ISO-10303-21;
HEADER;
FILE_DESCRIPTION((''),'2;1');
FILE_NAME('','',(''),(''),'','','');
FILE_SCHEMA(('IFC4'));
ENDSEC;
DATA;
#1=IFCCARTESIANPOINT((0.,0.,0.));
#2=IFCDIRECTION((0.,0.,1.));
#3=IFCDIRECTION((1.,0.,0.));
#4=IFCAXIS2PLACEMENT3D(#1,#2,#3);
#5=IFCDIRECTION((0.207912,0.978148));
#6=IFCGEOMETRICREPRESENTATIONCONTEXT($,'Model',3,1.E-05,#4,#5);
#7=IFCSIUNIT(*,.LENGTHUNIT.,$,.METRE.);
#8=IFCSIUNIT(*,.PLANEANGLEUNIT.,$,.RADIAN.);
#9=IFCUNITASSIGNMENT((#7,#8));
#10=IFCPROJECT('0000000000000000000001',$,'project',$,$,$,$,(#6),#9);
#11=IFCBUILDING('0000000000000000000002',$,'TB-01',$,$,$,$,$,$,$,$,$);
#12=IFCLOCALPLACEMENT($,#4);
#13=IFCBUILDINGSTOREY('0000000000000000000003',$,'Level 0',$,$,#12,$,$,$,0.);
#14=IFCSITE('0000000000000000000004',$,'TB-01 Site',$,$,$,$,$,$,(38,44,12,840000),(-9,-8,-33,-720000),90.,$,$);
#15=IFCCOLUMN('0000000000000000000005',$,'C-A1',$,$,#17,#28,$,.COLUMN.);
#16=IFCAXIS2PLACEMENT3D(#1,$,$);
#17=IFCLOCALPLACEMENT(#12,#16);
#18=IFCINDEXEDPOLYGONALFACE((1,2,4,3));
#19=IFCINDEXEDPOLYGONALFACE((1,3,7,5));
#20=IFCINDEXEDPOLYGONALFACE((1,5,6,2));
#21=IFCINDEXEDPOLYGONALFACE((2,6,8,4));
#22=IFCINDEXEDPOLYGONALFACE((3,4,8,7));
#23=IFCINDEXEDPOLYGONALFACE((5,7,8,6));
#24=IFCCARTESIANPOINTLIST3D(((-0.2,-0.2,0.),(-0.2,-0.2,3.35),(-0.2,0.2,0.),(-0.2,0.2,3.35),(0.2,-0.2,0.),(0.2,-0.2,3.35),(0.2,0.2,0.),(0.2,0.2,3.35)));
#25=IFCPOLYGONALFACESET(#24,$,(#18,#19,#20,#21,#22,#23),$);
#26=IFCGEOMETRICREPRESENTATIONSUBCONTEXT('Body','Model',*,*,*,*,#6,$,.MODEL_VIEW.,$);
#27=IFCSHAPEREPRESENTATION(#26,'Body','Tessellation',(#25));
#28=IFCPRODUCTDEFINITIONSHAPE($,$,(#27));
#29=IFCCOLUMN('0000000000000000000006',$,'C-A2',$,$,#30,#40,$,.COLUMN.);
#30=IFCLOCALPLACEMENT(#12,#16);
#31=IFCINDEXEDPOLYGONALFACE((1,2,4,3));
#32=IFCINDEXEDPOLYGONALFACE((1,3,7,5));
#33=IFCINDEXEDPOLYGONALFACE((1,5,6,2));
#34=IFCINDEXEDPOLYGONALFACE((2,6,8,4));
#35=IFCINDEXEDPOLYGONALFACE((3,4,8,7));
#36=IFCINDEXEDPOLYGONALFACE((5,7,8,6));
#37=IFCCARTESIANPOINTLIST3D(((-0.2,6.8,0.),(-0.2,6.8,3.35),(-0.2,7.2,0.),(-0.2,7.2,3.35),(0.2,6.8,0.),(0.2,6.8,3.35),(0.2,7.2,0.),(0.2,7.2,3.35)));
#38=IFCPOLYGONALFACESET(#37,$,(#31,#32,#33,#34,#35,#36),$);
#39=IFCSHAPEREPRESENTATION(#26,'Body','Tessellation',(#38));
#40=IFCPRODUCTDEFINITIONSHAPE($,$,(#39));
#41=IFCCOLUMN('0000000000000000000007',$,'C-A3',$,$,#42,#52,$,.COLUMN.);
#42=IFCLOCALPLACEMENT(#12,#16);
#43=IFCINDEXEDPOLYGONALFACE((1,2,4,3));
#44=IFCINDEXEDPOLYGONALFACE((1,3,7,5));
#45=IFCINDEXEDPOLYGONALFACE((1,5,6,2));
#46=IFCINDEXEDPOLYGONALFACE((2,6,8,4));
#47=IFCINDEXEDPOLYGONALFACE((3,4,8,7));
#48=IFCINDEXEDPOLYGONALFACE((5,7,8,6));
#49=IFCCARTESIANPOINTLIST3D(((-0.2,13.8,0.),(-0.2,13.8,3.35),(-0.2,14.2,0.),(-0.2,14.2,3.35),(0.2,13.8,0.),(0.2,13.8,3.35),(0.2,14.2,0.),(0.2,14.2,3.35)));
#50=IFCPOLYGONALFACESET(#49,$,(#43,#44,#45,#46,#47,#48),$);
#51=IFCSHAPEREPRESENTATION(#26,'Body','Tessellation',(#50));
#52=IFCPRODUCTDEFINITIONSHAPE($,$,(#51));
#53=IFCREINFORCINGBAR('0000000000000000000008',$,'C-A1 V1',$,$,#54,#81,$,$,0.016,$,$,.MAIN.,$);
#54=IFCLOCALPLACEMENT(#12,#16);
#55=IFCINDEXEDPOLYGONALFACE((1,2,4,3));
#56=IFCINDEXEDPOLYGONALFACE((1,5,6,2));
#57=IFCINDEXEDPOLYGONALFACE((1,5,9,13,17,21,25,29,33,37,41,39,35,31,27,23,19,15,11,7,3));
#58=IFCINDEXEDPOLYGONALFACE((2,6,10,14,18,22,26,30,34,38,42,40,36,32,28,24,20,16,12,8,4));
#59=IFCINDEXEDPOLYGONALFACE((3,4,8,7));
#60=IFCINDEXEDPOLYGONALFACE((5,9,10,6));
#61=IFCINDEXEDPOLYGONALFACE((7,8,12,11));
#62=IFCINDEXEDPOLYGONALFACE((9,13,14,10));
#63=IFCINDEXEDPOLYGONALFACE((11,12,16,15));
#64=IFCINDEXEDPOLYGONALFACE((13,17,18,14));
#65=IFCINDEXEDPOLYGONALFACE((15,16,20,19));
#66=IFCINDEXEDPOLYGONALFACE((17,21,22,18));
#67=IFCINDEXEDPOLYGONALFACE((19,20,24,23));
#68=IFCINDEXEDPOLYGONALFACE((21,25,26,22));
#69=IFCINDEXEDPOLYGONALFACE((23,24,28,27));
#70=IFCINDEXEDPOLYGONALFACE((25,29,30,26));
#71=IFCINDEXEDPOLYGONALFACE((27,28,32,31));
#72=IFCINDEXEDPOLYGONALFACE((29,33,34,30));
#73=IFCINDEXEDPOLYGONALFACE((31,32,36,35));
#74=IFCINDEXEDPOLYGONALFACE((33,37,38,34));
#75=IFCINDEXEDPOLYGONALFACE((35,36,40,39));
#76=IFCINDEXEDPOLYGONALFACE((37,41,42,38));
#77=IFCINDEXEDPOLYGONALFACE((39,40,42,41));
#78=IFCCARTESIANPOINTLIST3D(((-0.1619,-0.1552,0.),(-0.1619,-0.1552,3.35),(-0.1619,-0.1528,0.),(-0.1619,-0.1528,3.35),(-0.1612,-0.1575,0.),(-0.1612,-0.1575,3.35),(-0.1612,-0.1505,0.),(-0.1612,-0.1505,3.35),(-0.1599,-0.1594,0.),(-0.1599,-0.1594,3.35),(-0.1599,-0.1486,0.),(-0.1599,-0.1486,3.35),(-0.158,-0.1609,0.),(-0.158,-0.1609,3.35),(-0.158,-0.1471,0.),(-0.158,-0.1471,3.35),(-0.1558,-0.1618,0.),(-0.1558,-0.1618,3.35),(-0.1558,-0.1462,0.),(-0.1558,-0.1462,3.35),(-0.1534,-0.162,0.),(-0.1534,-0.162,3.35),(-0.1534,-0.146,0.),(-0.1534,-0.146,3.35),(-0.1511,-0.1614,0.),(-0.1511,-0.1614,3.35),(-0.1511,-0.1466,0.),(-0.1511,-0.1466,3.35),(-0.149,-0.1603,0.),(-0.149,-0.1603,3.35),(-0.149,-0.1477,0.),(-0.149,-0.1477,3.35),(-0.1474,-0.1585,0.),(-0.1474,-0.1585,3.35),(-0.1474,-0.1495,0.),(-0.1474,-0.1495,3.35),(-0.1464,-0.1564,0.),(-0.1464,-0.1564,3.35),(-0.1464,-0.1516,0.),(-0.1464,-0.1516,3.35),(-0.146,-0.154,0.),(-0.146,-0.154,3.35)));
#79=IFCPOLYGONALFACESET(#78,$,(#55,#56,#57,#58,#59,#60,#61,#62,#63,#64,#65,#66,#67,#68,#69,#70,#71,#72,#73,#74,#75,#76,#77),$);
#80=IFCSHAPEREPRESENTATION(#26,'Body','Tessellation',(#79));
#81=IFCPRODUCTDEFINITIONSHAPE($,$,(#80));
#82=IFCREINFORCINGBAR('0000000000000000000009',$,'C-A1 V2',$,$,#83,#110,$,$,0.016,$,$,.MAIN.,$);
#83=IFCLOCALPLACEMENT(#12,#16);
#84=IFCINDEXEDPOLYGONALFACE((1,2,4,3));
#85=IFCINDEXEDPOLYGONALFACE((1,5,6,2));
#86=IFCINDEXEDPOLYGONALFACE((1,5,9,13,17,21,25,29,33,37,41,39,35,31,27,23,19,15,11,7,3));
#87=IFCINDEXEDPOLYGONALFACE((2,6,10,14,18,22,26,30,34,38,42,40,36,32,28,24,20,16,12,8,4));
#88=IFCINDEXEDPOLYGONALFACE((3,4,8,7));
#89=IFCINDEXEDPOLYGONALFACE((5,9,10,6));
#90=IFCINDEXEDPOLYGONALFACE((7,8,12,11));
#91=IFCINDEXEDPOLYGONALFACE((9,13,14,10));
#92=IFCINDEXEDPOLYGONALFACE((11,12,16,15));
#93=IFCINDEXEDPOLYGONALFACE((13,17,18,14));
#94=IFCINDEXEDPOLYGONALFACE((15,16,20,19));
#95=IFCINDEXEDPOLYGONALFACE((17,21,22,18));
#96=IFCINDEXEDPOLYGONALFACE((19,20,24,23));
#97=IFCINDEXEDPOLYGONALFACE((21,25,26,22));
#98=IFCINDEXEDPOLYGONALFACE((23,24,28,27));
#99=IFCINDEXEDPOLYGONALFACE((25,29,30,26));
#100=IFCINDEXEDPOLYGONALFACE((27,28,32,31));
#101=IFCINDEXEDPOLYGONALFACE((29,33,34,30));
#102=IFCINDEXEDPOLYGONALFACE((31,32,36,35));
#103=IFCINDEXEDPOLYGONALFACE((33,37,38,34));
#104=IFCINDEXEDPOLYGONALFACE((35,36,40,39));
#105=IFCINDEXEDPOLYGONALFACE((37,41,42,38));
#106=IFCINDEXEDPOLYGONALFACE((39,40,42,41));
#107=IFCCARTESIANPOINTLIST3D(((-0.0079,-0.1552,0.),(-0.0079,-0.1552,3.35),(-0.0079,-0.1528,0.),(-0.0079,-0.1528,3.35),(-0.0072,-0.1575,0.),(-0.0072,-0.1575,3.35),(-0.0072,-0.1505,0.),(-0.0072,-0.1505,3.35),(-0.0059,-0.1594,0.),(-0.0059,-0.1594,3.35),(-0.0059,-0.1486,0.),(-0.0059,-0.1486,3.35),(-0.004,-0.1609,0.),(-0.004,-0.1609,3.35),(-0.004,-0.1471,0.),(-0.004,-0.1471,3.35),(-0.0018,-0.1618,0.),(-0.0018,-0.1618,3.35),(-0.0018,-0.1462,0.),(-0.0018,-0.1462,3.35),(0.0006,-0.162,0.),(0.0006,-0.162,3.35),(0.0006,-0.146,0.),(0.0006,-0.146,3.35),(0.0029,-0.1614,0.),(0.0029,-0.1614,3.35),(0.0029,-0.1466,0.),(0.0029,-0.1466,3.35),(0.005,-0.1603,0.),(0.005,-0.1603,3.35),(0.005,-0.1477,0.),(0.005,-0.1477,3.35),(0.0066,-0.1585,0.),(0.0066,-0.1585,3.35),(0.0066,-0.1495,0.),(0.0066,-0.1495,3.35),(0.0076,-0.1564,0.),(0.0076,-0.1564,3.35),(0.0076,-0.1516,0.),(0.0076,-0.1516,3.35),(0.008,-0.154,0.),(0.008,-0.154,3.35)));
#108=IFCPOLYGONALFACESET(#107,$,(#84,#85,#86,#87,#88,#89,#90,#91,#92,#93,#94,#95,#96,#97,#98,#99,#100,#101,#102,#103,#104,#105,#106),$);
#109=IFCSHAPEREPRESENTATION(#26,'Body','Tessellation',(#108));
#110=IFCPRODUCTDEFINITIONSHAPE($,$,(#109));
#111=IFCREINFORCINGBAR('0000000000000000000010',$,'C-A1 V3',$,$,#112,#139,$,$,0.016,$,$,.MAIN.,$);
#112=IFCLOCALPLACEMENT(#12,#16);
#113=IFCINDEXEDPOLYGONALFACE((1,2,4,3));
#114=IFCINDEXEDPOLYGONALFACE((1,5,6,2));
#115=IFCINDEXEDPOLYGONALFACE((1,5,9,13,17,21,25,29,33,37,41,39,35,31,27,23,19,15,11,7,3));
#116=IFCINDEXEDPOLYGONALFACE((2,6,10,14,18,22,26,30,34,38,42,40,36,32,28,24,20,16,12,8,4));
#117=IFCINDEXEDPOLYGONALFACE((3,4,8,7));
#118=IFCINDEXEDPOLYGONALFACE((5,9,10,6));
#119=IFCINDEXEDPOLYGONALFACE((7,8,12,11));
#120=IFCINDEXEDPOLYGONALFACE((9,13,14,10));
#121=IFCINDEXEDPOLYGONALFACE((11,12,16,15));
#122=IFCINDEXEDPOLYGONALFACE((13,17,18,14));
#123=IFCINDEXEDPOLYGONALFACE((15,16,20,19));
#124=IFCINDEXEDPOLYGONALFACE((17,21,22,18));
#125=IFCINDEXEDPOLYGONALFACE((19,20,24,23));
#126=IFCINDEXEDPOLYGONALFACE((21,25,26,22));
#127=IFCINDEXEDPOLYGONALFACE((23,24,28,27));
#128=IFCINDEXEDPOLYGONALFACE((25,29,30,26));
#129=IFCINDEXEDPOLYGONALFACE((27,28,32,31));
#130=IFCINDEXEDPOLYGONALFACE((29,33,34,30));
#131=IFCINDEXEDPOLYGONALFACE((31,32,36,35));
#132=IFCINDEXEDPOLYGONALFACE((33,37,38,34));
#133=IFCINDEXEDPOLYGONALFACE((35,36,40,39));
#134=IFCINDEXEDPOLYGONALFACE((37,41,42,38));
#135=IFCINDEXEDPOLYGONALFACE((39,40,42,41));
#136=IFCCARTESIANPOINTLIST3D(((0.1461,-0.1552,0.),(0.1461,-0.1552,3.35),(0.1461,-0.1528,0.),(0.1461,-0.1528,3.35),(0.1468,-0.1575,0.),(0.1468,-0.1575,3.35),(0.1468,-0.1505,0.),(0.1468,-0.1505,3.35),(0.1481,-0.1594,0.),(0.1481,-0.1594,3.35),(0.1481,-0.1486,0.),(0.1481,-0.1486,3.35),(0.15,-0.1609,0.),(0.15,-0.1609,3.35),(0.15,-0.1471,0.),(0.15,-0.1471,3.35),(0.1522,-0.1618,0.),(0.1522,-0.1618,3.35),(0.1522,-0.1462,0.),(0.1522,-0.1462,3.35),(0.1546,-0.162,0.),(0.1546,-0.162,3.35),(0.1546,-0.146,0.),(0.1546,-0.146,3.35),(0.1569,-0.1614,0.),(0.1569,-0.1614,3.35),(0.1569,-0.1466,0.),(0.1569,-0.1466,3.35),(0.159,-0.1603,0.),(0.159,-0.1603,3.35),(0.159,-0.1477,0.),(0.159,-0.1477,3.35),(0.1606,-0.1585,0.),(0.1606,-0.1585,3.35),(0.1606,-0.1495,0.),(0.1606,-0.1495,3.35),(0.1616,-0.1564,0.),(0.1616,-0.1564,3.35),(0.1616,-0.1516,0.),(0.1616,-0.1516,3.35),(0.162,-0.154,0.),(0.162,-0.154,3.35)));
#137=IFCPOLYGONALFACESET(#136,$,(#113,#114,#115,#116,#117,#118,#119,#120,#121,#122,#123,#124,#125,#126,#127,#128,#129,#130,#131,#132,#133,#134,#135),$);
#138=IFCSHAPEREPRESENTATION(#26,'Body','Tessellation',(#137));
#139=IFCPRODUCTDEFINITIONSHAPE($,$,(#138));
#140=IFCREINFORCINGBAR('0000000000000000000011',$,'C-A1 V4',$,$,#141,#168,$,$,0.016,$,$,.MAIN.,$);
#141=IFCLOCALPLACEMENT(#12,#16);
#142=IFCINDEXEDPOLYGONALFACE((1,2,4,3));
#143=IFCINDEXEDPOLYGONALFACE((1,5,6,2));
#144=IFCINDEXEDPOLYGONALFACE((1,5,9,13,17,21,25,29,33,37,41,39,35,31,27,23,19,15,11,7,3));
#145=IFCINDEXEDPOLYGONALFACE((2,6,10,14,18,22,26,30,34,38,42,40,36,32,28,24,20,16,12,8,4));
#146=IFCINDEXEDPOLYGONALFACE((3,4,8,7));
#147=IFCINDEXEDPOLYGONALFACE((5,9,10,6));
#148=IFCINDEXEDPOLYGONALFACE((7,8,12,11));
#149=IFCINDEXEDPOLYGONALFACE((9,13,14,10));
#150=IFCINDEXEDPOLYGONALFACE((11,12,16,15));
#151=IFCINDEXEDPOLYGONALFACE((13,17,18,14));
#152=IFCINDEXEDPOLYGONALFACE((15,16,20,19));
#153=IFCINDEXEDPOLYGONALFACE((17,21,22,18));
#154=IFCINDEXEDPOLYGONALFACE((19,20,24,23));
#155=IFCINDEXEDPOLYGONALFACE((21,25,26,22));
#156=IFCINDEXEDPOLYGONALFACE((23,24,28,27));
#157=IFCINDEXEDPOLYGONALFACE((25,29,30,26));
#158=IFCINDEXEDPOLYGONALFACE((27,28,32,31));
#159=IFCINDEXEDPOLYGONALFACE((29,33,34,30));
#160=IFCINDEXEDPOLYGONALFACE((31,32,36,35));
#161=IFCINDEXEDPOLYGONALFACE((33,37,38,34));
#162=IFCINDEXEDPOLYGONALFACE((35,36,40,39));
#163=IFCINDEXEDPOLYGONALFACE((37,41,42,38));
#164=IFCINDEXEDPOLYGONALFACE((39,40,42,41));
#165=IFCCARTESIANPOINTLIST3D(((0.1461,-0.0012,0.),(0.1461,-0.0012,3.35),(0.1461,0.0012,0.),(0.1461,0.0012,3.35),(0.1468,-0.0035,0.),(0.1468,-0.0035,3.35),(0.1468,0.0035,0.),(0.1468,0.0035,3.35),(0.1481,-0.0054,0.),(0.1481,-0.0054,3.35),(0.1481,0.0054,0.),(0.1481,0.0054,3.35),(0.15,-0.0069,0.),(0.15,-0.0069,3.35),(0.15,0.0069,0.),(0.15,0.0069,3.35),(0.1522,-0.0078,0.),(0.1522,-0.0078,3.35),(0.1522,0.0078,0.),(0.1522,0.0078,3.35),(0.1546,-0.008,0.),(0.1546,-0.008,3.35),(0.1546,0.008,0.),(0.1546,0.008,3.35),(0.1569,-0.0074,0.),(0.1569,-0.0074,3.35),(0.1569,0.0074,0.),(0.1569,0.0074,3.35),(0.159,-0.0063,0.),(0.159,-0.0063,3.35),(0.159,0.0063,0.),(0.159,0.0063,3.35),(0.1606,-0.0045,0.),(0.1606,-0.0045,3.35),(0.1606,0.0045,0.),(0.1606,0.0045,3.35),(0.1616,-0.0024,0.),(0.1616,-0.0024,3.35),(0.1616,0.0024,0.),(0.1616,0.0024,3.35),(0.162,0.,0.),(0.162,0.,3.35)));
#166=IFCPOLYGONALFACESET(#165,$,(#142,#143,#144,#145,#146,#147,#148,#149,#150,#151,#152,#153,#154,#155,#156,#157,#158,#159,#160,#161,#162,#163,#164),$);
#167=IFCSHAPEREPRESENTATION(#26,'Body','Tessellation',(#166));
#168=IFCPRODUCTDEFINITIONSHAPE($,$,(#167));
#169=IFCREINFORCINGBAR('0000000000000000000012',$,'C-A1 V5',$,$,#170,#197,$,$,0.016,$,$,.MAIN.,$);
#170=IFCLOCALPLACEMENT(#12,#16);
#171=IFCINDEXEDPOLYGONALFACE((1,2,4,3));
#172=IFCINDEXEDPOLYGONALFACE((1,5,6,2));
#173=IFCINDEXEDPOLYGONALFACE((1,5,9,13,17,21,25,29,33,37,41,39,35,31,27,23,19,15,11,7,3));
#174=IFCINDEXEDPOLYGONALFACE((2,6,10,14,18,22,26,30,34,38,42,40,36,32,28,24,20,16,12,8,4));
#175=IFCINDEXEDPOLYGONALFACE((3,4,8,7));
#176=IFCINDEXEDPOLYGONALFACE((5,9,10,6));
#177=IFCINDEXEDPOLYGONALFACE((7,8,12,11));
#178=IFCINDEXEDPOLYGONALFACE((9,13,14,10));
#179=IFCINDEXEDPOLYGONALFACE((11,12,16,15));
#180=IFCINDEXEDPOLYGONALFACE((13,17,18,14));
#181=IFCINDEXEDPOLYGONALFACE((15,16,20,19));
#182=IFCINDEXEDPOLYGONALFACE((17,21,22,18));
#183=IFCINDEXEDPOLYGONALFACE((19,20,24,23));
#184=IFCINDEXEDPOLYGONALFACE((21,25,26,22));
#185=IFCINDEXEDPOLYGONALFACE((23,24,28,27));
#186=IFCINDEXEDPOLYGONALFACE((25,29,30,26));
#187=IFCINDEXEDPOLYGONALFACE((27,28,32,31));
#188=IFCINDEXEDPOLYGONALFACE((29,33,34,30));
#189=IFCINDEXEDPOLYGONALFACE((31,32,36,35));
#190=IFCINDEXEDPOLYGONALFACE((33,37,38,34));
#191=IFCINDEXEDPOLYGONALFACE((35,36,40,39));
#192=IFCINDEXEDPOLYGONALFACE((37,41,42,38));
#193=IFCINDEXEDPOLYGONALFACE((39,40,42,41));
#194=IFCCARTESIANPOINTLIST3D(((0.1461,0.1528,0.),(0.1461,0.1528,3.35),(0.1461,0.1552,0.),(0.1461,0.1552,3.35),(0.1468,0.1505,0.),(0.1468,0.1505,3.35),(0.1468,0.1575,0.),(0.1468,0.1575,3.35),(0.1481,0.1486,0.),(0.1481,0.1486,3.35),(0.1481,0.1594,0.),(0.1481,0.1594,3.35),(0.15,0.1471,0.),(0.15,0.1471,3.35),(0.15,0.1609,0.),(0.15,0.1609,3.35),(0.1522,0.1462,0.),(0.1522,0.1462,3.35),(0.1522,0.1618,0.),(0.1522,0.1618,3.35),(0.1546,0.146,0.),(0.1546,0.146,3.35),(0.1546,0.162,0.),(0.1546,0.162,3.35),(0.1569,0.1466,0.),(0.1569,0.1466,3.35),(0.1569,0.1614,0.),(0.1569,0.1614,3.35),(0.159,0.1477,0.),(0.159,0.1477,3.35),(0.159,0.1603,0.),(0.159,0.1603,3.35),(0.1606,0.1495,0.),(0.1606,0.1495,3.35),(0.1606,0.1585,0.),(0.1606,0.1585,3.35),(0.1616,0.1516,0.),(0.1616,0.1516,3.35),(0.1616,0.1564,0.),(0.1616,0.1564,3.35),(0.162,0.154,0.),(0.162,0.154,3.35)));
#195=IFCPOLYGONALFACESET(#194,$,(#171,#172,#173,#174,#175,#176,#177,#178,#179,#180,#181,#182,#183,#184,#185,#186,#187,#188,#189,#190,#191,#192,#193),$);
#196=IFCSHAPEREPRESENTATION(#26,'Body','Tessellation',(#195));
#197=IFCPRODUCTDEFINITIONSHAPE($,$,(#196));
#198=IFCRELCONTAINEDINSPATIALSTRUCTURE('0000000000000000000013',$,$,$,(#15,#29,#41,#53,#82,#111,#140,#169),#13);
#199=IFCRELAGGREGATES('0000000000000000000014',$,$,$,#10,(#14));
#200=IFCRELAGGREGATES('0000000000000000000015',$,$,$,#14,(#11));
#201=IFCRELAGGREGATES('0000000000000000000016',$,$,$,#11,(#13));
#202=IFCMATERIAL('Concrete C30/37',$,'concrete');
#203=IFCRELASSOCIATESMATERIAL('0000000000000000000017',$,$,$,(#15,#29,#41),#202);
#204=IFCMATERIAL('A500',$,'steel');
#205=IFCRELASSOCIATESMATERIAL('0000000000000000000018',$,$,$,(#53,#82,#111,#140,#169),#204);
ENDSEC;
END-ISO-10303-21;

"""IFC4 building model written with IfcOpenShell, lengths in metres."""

from ifc_helpers import new_model, entity, si_unit, direction, frame, origin_with_axes, place, context, subcontext, project, spatial, rectangle, extrude, material, element, save


model = new_model("IFC4")

# Units and contexts
model_context = context("Model", 3, precision=1e-05, world=origin_with_axes(), true_north=direction((0.207912, 0.978148)))
body_context = subcontext(model_context, "Body", "Model", "MODEL_VIEW")
ifc_project = project(units=[si_unit("LENGTHUNIT", "METRE"), si_unit("PLANEANGLEUNIT", "RADIAN")], contexts=[model_context])

# Site, building, storey
site = spatial("IfcSite", under=ifc_project, Name="TB-01 Site", RefLatitude=(38, 44, 12, 840000), RefLongitude=(-9, -8, -33, -720000), RefElevation=90.0)
building = spatial("IfcBuilding", under=site, Name="TB-01")
storey_placement = place(None, origin_with_axes())
storey = spatial("IfcBuildingStorey", under=building, at=storey_placement, Name="Level 0", Elevation=0.0)

# Columns
ifc_material_1 = material(Name="Concrete C30/37", Category="concrete")
column_1_placement = place(storey_placement, origin_with_axes())
element("IfcColumn", 1, at=column_1_placement, inside=storey, material=ifc_material_1, Name="C-A1", PredefinedType="COLUMN", context=body_context, shape_type="SweptSolid", body=[
    extrude(rectangle(XDim=0.4, YDim=0.4), origin_with_axes(), (0.0, 0.0, 1.0), 3.35),
])
column_2_placement = place(storey_placement, frame((0.0, 7.0, 0.0), z_axis=(0.0, 0.0, 1.0), x_axis=(1.0, 0.0, 0.0)))
element("IfcColumn", 2, at=column_2_placement, inside=storey, material=ifc_material_1, Name="C-A2", PredefinedType="COLUMN", context=body_context, shape_type="SweptSolid", body=[
    extrude(rectangle(XDim=0.4, YDim=0.4), origin_with_axes(), (0.0, 0.0, 1.0), 3.35),
])
column_3_placement = place(storey_placement, frame((0.0, 14.0, 0.0), z_axis=(0.0, 0.0, 1.0), x_axis=(1.0, 0.0, 0.0)))
element("IfcColumn", 3, at=column_3_placement, inside=storey, material=ifc_material_1, Name="C-A3", PredefinedType="COLUMN", context=body_context, shape_type="SweptSolid", body=[
    extrude(rectangle(XDim=0.4, YDim=0.4), origin_with_axes(), (0.0, 0.0, 1.0), 3.35),
])

# Reinforcing bars
ifc_material_2 = material(Name="A500", Category="steel")
reinforcing_bar_1_placement = place(storey_placement, origin_with_axes())
element("IfcReinforcingBar", 4, at=reinforcing_bar_1_placement, inside=storey, material=ifc_material_2, Name="C-A1 V1", NominalDiameter=0.016, PredefinedType="MAIN", context=body_context, shape_type="AdvancedSweptSolid", body=[
    entity("IfcSweptDiskSolid", entity("IfcPolyline", [entity("IfcCartesianPoint", [-0.154, -0.154, 0.0]), entity("IfcCartesianPoint", [-0.154, -0.154, 3.35])]), 0.008),
])
reinforcing_bar_2_placement = place(storey_placement, origin_with_axes())
element("IfcReinforcingBar", 5, at=reinforcing_bar_2_placement, inside=storey, material=ifc_material_2, Name="C-A1 V2", NominalDiameter=0.016, PredefinedType="MAIN", context=body_context, shape_type="AdvancedSweptSolid", body=[
    entity("IfcSweptDiskSolid", entity("IfcPolyline", [entity("IfcCartesianPoint", [0.0, -0.154, 0.0]), entity("IfcCartesianPoint", [0.0, -0.154, 3.35])]), 0.008),
])
reinforcing_bar_3_placement = place(storey_placement, origin_with_axes())
element("IfcReinforcingBar", 6, at=reinforcing_bar_3_placement, inside=storey, material=ifc_material_2, Name="C-A1 V3", NominalDiameter=0.016, PredefinedType="MAIN", context=body_context, shape_type="AdvancedSweptSolid", body=[
    entity("IfcSweptDiskSolid", entity("IfcPolyline", [entity("IfcCartesianPoint", [0.154, -0.154, 0.0]), entity("IfcCartesianPoint", [0.154, -0.154, 3.35])]), 0.008),
])
reinforcing_bar_4_placement = place(storey_placement, origin_with_axes())
element("IfcReinforcingBar", 7, at=reinforcing_bar_4_placement, inside=storey, material=ifc_material_2, Name="C-A1 V4", NominalDiameter=0.016, PredefinedType="MAIN", context=body_context, shape_type="AdvancedSweptSolid", body=[
    entity("IfcSweptDiskSolid", entity("IfcPolyline", [entity("IfcCartesianPoint", [0.154, 0.0, 0.0]), entity("IfcCartesianPoint", [0.154, 0.0, 3.35])]), 0.008),
])
reinforcing_bar_5_placement = place(storey_placement, origin_with_axes())
element("IfcReinforcingBar", 8, at=reinforcing_bar_5_placement, inside=storey, material=ifc_material_2, Name="C-A1 V5", NominalDiameter=0.016, PredefinedType="MAIN", context=body_context, shape_type="AdvancedSweptSolid", body=[
    entity("IfcSweptDiskSolid", entity("IfcPolyline", [entity("IfcCartesianPoint", [0.154, 0.154, 0.0]), entity("IfcCartesianPoint", [0.154, 0.154, 3.35])]), 0.008),
])

save(model, "model.ifc")
